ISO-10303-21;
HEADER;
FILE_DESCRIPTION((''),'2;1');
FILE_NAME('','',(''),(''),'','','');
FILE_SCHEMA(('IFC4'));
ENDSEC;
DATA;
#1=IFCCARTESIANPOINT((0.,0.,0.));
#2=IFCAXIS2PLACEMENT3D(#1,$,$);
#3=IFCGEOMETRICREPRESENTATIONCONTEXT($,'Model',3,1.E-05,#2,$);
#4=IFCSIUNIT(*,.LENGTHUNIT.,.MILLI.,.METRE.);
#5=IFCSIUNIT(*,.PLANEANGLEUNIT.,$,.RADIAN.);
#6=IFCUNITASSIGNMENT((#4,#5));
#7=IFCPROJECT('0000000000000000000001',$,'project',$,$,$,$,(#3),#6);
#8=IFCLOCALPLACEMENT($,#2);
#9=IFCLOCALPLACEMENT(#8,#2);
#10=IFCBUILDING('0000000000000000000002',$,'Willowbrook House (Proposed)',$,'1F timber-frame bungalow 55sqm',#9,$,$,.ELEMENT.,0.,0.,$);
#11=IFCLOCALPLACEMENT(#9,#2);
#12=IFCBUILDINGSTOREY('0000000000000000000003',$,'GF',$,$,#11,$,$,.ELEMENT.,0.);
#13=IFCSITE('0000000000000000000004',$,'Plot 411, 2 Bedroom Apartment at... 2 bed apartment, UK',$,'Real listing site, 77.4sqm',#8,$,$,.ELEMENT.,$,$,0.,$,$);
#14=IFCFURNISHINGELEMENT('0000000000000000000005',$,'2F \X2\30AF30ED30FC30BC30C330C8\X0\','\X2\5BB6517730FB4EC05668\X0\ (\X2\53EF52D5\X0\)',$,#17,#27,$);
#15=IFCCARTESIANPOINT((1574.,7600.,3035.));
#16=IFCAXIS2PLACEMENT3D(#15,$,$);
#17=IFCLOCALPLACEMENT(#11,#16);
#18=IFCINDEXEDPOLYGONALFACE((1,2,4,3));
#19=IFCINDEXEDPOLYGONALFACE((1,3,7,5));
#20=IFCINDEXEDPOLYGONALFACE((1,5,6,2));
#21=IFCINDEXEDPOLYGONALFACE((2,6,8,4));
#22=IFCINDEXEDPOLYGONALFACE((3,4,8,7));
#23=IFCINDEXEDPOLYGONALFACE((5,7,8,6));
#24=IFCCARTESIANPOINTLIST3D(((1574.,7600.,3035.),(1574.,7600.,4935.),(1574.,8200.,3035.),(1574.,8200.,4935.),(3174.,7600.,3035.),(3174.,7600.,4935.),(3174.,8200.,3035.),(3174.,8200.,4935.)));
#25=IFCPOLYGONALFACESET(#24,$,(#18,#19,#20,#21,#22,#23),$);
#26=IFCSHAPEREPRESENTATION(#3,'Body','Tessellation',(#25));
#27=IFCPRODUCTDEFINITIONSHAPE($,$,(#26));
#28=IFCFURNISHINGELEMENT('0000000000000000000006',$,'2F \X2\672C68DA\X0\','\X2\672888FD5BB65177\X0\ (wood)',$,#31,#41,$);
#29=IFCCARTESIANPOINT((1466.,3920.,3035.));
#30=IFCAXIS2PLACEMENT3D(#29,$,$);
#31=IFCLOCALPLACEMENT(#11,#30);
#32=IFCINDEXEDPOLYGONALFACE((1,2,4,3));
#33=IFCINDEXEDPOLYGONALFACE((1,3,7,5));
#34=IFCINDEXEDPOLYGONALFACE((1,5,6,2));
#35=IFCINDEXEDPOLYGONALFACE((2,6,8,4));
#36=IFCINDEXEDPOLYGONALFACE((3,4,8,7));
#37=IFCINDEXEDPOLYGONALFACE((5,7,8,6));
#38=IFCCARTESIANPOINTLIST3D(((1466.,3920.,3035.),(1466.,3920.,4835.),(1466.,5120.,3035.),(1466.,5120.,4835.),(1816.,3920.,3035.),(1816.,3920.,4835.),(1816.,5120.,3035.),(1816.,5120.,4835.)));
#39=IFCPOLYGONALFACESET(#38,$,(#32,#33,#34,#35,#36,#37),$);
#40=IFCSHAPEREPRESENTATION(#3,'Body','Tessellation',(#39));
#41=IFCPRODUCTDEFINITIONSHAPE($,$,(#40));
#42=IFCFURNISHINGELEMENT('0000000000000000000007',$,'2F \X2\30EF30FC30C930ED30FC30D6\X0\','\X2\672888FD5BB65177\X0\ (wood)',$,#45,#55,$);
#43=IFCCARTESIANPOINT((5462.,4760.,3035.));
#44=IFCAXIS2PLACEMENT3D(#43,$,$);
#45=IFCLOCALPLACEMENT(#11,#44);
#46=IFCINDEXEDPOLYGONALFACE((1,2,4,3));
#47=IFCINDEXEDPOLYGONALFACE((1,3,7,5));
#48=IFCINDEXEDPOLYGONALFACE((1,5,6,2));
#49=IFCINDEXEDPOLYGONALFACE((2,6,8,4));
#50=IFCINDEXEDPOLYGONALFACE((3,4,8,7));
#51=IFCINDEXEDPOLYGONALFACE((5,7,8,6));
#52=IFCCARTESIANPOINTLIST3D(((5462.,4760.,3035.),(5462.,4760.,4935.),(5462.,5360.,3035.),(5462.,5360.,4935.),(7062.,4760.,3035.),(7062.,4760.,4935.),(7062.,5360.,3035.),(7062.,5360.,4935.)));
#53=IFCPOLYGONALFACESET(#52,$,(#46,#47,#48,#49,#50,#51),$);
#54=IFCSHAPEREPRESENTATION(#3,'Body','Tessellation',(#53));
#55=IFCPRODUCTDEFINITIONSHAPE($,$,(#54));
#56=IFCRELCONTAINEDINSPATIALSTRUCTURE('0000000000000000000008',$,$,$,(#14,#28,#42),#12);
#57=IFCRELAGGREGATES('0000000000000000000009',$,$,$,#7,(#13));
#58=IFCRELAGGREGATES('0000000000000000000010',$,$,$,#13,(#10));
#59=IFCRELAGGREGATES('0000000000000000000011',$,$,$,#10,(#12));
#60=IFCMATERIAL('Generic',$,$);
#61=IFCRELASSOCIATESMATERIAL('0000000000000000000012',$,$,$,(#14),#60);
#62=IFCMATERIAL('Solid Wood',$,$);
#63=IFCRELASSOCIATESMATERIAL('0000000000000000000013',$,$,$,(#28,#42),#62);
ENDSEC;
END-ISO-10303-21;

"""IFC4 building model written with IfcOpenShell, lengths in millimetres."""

from ifc_helpers import new_model, si_unit, frame, frame_2d, origin, place, context, project, spatial, rectangle, extrude, material, element, save


model = new_model("IFC4")

# Units and contexts
model_context = context("Model", 3, precision=1e-05, world=origin())
ifc_project = project(units=[si_unit("LENGTHUNIT", "METRE", prefix="MILLI"), si_unit("PLANEANGLEUNIT", "RADIAN")], contexts=[model_context])

# Site, building, storey
site_placement = place(None, origin())
site = spatial("IfcSite", under=ifc_project, at=site_placement, Name="Plot 411, 2 Bedroom Apartment at... 2 bed apartment, UK", ObjectType="Real listing site, 77.4sqm", CompositionType="ELEMENT", RefElevation=0.0)
building_placement = place(site_placement, origin())
building = spatial("IfcBuilding", under=site, at=building_placement, Name="Willowbrook House (Proposed)", ObjectType="1F timber-frame bungalow 55sqm", CompositionType="ELEMENT", ElevationOfRefHeight=0.0, ElevationOfTerrain=0.0)
storey_placement = place(building_placement, origin())
storey = spatial("IfcBuildingStorey", under=building, at=storey_placement, Name="GF", CompositionType="ELEMENT", Elevation=0.0)

# Shared definitions
ifc_material_1 = material(Name="Solid Wood")

# Shared definitions
ifc_material_2 = material(Name="Generic")

# Furnishing elements
furnishing_1_placement = place(storey_placement, frame((1574.0, 7600.0, 3035.0)))
element("IfcFurnishingElement", 1, at=furnishing_1_placement, inside=storey, material=ifc_material_2, Name="2F クローゼット", Description="家具・什器 (可動)", context=model_context, shape_type="SweptSolid", body=[
    extrude(rectangle(XDim=1600.0, YDim=600.0, at=frame_2d((800.0, 300.0))), frame((1574.0, 7600.0, 3035.0)), (0.0, 0.0, 1.0), 1900.0),
])
furnishing_2_placement = place(storey_placement, frame((1466.0, 3920.0, 3035.0)))
element("IfcFurnishingElement", 2, at=furnishing_2_placement, inside=storey, material=ifc_material_1, Name="2F 本棚", Description="木製家具 (wood)", context=model_context, shape_type="SweptSolid", body=[
    extrude(rectangle(XDim=350.0, YDim=1200.0, at=frame_2d((175.0, 600.0))), frame((1466.0, 3920.0, 3035.0)), (0.0, 0.0, 1.0), 1800.0),
])
furnishing_3_placement = place(storey_placement, frame((5462.0, 4760.0, 3035.0)))
element("IfcFurnishingElement", 3, at=furnishing_3_placement, inside=storey, material=ifc_material_1, Name="2F ワードローブ", Description="木製家具 (wood)", context=model_context, shape_type="SweptSolid", body=[
    extrude(rectangle(XDim=1600.0, YDim=600.0, at=frame_2d((800.0, 300.0))), frame((5462.0, 4760.0, 3035.0)), (0.0, 0.0, 1.0), 1900.0),
])

save(model, "model.ifc")
